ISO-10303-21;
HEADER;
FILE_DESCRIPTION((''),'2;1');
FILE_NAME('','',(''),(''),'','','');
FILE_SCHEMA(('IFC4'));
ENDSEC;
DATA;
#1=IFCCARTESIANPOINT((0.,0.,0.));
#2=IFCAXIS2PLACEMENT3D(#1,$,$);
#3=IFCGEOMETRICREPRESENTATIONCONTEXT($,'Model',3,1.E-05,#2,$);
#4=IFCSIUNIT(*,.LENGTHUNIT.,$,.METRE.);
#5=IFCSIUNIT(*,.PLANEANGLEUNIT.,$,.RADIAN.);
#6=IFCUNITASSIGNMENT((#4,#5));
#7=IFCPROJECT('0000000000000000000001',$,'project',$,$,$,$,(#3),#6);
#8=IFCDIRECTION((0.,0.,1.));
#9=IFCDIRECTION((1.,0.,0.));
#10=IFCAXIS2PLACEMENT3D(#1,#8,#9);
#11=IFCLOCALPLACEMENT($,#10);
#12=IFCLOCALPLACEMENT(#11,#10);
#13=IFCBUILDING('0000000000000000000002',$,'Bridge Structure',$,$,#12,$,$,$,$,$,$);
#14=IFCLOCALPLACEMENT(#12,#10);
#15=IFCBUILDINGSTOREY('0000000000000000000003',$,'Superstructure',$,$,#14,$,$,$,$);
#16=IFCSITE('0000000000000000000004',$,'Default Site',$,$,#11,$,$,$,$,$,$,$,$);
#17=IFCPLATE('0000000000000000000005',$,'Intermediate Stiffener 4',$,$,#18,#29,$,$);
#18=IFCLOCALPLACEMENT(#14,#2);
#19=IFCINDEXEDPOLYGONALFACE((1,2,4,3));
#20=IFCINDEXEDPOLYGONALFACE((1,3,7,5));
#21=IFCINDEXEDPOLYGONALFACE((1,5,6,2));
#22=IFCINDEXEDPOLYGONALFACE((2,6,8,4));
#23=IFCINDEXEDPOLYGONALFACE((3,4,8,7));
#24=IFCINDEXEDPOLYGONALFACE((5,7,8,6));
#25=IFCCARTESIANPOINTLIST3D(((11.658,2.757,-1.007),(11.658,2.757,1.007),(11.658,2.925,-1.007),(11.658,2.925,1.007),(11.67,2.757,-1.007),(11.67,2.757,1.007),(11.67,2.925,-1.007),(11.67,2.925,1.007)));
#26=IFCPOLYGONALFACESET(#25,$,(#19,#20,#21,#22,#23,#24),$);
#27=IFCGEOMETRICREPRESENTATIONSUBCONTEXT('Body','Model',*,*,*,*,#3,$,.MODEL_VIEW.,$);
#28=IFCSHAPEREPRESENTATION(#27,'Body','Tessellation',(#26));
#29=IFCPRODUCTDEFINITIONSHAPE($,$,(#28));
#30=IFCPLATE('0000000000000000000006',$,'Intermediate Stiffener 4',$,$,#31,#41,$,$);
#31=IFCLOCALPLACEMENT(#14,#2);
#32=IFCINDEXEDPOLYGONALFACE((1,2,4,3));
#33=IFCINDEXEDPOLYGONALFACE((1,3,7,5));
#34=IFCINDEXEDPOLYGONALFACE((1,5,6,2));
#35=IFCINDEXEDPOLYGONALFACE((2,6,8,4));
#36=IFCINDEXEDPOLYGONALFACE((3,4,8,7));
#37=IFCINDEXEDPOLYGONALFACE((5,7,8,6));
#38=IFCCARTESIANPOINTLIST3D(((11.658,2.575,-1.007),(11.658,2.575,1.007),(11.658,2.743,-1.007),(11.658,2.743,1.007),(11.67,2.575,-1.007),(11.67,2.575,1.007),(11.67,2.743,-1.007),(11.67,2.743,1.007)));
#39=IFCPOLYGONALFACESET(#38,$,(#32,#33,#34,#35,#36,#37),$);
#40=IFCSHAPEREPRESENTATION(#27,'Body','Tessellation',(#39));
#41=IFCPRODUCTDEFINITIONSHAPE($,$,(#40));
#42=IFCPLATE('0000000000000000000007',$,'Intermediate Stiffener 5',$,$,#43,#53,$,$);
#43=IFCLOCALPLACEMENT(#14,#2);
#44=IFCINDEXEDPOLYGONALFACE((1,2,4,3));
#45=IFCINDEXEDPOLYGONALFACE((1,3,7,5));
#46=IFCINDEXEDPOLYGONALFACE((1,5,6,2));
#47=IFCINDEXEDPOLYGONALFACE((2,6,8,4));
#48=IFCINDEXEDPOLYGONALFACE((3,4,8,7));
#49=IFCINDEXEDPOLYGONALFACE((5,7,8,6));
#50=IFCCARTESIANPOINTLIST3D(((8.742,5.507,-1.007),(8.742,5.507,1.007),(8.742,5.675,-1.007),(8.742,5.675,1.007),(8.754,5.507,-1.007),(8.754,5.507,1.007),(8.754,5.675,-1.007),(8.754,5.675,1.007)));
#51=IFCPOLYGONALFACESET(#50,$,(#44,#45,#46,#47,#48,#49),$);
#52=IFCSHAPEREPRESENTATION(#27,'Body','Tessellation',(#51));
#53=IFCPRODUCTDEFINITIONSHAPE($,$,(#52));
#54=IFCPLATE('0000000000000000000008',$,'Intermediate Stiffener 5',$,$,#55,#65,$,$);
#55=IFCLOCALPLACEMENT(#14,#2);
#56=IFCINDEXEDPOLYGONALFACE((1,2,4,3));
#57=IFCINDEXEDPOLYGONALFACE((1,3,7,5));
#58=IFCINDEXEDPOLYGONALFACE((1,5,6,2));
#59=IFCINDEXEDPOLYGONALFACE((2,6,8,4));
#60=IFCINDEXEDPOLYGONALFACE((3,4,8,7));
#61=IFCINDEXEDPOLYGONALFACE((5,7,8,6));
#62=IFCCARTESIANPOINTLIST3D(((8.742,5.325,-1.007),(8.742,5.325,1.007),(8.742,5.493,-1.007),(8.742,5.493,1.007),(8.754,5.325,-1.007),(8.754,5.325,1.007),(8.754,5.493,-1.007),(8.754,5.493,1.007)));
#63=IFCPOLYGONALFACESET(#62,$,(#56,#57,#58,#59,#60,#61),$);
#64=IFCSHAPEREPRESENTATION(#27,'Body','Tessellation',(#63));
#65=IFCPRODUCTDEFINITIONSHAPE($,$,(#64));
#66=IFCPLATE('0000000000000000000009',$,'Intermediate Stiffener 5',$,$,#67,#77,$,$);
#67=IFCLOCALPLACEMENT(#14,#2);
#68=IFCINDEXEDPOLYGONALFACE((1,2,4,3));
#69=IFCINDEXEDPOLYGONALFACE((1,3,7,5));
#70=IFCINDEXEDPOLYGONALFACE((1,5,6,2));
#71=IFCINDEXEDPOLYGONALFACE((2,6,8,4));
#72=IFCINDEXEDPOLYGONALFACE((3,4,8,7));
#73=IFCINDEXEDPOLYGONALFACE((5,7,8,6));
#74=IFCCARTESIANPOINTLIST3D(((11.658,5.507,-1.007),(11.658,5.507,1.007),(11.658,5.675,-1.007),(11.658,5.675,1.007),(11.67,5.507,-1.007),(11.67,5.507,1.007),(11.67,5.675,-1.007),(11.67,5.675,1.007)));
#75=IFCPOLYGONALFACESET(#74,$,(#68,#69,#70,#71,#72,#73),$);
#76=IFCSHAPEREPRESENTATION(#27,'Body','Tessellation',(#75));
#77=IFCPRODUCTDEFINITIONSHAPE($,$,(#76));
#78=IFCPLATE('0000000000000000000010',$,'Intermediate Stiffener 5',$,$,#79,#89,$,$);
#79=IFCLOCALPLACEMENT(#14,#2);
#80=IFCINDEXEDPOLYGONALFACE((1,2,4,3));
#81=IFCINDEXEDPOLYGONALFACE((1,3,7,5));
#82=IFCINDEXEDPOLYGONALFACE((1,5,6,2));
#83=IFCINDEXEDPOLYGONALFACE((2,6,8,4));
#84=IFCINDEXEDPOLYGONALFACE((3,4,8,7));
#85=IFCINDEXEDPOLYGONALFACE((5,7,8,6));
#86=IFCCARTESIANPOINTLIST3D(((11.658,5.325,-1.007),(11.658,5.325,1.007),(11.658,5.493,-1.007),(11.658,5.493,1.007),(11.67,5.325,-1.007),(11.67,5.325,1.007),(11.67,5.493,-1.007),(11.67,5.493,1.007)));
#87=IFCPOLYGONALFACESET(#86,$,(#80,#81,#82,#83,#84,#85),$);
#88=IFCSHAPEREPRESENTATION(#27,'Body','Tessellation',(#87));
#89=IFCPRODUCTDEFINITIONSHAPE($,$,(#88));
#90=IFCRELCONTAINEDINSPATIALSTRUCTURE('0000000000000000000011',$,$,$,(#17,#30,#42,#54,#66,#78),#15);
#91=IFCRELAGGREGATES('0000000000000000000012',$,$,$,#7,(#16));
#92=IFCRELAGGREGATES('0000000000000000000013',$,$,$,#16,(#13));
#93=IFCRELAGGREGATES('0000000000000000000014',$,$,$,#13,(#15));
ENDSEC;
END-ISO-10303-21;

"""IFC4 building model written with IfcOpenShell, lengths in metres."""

from ifc_helpers import new_model, si_unit, frame, origin, origin_with_axes, origin_2d_with_axis, place, context, subcontext, project, spatial, rectangle, extrude, element, save


model = new_model("IFC4")

# Units and contexts
model_context = context("Model", 3, precision=1e-05, world=origin())
body_context = subcontext(model_context, "Body", "Model", "MODEL_VIEW")
ifc_project = project(units=[si_unit("LENGTHUNIT", "METRE"), si_unit("PLANEANGLEUNIT", "RADIAN")], contexts=[model_context])

# Site, building, storey
site_placement = place(None, origin_with_axes())
site = spatial("IfcSite", under=ifc_project, at=site_placement, Name="Default Site")
building_placement = place(site_placement, origin_with_axes())
building = spatial("IfcBuilding", under=site, at=building_placement, Name="Bridge Structure")
storey_placement = place(building_placement, origin_with_axes())
storey = spatial("IfcBuildingStorey", under=building, at=storey_placement, Name="Superstructure")

# Plates
for number, where, z_axis, x_axis, name in (
    (1, (11.664, 2.841, -1.007), (0.0, 0.0, 1.0), (1.0, 0.0, 0.0), "Intermediate Stiffener 4"),
    (2, (11.664, 2.659, -1.007), (0.0, 0.0, 1.0), (1.0, 0.0, 0.0), "Intermediate Stiffener 4"),
    (3, (8.748, 5.591, -1.007), (0.0, 0.0, 1.0), (1.0, 0.0, 0.0), "Intermediate Stiffener 5"),
    (4, (8.748, 5.409, -1.007), (0.0, 0.0, 1.0), (1.0, 0.0, 0.0), "Intermediate Stiffener 5"),
    (5, (11.664, 5.591, -1.007), (0.0, 0.0, 1.0), (1.0, 0.0, 0.0), "Intermediate Stiffener 5"),
    (6, (11.664, 5.409, -1.007), (0.0, 0.0, 1.0), (1.0, 0.0, 0.0), "Intermediate Stiffener 5"),
):
    element("IfcPlate", number, at=place(storey_placement, frame(where, z_axis=z_axis, x_axis=x_axis)), inside=storey, Name=name, context=body_context, shape_type="SweptSolid", body=[
        extrude(rectangle(XDim=0.012, YDim=0.168, at=origin_2d_with_axis()), origin_with_axes(), (0.0, 0.0, 1.0), 2.014),
    ])

save(model, "model.ifc")
